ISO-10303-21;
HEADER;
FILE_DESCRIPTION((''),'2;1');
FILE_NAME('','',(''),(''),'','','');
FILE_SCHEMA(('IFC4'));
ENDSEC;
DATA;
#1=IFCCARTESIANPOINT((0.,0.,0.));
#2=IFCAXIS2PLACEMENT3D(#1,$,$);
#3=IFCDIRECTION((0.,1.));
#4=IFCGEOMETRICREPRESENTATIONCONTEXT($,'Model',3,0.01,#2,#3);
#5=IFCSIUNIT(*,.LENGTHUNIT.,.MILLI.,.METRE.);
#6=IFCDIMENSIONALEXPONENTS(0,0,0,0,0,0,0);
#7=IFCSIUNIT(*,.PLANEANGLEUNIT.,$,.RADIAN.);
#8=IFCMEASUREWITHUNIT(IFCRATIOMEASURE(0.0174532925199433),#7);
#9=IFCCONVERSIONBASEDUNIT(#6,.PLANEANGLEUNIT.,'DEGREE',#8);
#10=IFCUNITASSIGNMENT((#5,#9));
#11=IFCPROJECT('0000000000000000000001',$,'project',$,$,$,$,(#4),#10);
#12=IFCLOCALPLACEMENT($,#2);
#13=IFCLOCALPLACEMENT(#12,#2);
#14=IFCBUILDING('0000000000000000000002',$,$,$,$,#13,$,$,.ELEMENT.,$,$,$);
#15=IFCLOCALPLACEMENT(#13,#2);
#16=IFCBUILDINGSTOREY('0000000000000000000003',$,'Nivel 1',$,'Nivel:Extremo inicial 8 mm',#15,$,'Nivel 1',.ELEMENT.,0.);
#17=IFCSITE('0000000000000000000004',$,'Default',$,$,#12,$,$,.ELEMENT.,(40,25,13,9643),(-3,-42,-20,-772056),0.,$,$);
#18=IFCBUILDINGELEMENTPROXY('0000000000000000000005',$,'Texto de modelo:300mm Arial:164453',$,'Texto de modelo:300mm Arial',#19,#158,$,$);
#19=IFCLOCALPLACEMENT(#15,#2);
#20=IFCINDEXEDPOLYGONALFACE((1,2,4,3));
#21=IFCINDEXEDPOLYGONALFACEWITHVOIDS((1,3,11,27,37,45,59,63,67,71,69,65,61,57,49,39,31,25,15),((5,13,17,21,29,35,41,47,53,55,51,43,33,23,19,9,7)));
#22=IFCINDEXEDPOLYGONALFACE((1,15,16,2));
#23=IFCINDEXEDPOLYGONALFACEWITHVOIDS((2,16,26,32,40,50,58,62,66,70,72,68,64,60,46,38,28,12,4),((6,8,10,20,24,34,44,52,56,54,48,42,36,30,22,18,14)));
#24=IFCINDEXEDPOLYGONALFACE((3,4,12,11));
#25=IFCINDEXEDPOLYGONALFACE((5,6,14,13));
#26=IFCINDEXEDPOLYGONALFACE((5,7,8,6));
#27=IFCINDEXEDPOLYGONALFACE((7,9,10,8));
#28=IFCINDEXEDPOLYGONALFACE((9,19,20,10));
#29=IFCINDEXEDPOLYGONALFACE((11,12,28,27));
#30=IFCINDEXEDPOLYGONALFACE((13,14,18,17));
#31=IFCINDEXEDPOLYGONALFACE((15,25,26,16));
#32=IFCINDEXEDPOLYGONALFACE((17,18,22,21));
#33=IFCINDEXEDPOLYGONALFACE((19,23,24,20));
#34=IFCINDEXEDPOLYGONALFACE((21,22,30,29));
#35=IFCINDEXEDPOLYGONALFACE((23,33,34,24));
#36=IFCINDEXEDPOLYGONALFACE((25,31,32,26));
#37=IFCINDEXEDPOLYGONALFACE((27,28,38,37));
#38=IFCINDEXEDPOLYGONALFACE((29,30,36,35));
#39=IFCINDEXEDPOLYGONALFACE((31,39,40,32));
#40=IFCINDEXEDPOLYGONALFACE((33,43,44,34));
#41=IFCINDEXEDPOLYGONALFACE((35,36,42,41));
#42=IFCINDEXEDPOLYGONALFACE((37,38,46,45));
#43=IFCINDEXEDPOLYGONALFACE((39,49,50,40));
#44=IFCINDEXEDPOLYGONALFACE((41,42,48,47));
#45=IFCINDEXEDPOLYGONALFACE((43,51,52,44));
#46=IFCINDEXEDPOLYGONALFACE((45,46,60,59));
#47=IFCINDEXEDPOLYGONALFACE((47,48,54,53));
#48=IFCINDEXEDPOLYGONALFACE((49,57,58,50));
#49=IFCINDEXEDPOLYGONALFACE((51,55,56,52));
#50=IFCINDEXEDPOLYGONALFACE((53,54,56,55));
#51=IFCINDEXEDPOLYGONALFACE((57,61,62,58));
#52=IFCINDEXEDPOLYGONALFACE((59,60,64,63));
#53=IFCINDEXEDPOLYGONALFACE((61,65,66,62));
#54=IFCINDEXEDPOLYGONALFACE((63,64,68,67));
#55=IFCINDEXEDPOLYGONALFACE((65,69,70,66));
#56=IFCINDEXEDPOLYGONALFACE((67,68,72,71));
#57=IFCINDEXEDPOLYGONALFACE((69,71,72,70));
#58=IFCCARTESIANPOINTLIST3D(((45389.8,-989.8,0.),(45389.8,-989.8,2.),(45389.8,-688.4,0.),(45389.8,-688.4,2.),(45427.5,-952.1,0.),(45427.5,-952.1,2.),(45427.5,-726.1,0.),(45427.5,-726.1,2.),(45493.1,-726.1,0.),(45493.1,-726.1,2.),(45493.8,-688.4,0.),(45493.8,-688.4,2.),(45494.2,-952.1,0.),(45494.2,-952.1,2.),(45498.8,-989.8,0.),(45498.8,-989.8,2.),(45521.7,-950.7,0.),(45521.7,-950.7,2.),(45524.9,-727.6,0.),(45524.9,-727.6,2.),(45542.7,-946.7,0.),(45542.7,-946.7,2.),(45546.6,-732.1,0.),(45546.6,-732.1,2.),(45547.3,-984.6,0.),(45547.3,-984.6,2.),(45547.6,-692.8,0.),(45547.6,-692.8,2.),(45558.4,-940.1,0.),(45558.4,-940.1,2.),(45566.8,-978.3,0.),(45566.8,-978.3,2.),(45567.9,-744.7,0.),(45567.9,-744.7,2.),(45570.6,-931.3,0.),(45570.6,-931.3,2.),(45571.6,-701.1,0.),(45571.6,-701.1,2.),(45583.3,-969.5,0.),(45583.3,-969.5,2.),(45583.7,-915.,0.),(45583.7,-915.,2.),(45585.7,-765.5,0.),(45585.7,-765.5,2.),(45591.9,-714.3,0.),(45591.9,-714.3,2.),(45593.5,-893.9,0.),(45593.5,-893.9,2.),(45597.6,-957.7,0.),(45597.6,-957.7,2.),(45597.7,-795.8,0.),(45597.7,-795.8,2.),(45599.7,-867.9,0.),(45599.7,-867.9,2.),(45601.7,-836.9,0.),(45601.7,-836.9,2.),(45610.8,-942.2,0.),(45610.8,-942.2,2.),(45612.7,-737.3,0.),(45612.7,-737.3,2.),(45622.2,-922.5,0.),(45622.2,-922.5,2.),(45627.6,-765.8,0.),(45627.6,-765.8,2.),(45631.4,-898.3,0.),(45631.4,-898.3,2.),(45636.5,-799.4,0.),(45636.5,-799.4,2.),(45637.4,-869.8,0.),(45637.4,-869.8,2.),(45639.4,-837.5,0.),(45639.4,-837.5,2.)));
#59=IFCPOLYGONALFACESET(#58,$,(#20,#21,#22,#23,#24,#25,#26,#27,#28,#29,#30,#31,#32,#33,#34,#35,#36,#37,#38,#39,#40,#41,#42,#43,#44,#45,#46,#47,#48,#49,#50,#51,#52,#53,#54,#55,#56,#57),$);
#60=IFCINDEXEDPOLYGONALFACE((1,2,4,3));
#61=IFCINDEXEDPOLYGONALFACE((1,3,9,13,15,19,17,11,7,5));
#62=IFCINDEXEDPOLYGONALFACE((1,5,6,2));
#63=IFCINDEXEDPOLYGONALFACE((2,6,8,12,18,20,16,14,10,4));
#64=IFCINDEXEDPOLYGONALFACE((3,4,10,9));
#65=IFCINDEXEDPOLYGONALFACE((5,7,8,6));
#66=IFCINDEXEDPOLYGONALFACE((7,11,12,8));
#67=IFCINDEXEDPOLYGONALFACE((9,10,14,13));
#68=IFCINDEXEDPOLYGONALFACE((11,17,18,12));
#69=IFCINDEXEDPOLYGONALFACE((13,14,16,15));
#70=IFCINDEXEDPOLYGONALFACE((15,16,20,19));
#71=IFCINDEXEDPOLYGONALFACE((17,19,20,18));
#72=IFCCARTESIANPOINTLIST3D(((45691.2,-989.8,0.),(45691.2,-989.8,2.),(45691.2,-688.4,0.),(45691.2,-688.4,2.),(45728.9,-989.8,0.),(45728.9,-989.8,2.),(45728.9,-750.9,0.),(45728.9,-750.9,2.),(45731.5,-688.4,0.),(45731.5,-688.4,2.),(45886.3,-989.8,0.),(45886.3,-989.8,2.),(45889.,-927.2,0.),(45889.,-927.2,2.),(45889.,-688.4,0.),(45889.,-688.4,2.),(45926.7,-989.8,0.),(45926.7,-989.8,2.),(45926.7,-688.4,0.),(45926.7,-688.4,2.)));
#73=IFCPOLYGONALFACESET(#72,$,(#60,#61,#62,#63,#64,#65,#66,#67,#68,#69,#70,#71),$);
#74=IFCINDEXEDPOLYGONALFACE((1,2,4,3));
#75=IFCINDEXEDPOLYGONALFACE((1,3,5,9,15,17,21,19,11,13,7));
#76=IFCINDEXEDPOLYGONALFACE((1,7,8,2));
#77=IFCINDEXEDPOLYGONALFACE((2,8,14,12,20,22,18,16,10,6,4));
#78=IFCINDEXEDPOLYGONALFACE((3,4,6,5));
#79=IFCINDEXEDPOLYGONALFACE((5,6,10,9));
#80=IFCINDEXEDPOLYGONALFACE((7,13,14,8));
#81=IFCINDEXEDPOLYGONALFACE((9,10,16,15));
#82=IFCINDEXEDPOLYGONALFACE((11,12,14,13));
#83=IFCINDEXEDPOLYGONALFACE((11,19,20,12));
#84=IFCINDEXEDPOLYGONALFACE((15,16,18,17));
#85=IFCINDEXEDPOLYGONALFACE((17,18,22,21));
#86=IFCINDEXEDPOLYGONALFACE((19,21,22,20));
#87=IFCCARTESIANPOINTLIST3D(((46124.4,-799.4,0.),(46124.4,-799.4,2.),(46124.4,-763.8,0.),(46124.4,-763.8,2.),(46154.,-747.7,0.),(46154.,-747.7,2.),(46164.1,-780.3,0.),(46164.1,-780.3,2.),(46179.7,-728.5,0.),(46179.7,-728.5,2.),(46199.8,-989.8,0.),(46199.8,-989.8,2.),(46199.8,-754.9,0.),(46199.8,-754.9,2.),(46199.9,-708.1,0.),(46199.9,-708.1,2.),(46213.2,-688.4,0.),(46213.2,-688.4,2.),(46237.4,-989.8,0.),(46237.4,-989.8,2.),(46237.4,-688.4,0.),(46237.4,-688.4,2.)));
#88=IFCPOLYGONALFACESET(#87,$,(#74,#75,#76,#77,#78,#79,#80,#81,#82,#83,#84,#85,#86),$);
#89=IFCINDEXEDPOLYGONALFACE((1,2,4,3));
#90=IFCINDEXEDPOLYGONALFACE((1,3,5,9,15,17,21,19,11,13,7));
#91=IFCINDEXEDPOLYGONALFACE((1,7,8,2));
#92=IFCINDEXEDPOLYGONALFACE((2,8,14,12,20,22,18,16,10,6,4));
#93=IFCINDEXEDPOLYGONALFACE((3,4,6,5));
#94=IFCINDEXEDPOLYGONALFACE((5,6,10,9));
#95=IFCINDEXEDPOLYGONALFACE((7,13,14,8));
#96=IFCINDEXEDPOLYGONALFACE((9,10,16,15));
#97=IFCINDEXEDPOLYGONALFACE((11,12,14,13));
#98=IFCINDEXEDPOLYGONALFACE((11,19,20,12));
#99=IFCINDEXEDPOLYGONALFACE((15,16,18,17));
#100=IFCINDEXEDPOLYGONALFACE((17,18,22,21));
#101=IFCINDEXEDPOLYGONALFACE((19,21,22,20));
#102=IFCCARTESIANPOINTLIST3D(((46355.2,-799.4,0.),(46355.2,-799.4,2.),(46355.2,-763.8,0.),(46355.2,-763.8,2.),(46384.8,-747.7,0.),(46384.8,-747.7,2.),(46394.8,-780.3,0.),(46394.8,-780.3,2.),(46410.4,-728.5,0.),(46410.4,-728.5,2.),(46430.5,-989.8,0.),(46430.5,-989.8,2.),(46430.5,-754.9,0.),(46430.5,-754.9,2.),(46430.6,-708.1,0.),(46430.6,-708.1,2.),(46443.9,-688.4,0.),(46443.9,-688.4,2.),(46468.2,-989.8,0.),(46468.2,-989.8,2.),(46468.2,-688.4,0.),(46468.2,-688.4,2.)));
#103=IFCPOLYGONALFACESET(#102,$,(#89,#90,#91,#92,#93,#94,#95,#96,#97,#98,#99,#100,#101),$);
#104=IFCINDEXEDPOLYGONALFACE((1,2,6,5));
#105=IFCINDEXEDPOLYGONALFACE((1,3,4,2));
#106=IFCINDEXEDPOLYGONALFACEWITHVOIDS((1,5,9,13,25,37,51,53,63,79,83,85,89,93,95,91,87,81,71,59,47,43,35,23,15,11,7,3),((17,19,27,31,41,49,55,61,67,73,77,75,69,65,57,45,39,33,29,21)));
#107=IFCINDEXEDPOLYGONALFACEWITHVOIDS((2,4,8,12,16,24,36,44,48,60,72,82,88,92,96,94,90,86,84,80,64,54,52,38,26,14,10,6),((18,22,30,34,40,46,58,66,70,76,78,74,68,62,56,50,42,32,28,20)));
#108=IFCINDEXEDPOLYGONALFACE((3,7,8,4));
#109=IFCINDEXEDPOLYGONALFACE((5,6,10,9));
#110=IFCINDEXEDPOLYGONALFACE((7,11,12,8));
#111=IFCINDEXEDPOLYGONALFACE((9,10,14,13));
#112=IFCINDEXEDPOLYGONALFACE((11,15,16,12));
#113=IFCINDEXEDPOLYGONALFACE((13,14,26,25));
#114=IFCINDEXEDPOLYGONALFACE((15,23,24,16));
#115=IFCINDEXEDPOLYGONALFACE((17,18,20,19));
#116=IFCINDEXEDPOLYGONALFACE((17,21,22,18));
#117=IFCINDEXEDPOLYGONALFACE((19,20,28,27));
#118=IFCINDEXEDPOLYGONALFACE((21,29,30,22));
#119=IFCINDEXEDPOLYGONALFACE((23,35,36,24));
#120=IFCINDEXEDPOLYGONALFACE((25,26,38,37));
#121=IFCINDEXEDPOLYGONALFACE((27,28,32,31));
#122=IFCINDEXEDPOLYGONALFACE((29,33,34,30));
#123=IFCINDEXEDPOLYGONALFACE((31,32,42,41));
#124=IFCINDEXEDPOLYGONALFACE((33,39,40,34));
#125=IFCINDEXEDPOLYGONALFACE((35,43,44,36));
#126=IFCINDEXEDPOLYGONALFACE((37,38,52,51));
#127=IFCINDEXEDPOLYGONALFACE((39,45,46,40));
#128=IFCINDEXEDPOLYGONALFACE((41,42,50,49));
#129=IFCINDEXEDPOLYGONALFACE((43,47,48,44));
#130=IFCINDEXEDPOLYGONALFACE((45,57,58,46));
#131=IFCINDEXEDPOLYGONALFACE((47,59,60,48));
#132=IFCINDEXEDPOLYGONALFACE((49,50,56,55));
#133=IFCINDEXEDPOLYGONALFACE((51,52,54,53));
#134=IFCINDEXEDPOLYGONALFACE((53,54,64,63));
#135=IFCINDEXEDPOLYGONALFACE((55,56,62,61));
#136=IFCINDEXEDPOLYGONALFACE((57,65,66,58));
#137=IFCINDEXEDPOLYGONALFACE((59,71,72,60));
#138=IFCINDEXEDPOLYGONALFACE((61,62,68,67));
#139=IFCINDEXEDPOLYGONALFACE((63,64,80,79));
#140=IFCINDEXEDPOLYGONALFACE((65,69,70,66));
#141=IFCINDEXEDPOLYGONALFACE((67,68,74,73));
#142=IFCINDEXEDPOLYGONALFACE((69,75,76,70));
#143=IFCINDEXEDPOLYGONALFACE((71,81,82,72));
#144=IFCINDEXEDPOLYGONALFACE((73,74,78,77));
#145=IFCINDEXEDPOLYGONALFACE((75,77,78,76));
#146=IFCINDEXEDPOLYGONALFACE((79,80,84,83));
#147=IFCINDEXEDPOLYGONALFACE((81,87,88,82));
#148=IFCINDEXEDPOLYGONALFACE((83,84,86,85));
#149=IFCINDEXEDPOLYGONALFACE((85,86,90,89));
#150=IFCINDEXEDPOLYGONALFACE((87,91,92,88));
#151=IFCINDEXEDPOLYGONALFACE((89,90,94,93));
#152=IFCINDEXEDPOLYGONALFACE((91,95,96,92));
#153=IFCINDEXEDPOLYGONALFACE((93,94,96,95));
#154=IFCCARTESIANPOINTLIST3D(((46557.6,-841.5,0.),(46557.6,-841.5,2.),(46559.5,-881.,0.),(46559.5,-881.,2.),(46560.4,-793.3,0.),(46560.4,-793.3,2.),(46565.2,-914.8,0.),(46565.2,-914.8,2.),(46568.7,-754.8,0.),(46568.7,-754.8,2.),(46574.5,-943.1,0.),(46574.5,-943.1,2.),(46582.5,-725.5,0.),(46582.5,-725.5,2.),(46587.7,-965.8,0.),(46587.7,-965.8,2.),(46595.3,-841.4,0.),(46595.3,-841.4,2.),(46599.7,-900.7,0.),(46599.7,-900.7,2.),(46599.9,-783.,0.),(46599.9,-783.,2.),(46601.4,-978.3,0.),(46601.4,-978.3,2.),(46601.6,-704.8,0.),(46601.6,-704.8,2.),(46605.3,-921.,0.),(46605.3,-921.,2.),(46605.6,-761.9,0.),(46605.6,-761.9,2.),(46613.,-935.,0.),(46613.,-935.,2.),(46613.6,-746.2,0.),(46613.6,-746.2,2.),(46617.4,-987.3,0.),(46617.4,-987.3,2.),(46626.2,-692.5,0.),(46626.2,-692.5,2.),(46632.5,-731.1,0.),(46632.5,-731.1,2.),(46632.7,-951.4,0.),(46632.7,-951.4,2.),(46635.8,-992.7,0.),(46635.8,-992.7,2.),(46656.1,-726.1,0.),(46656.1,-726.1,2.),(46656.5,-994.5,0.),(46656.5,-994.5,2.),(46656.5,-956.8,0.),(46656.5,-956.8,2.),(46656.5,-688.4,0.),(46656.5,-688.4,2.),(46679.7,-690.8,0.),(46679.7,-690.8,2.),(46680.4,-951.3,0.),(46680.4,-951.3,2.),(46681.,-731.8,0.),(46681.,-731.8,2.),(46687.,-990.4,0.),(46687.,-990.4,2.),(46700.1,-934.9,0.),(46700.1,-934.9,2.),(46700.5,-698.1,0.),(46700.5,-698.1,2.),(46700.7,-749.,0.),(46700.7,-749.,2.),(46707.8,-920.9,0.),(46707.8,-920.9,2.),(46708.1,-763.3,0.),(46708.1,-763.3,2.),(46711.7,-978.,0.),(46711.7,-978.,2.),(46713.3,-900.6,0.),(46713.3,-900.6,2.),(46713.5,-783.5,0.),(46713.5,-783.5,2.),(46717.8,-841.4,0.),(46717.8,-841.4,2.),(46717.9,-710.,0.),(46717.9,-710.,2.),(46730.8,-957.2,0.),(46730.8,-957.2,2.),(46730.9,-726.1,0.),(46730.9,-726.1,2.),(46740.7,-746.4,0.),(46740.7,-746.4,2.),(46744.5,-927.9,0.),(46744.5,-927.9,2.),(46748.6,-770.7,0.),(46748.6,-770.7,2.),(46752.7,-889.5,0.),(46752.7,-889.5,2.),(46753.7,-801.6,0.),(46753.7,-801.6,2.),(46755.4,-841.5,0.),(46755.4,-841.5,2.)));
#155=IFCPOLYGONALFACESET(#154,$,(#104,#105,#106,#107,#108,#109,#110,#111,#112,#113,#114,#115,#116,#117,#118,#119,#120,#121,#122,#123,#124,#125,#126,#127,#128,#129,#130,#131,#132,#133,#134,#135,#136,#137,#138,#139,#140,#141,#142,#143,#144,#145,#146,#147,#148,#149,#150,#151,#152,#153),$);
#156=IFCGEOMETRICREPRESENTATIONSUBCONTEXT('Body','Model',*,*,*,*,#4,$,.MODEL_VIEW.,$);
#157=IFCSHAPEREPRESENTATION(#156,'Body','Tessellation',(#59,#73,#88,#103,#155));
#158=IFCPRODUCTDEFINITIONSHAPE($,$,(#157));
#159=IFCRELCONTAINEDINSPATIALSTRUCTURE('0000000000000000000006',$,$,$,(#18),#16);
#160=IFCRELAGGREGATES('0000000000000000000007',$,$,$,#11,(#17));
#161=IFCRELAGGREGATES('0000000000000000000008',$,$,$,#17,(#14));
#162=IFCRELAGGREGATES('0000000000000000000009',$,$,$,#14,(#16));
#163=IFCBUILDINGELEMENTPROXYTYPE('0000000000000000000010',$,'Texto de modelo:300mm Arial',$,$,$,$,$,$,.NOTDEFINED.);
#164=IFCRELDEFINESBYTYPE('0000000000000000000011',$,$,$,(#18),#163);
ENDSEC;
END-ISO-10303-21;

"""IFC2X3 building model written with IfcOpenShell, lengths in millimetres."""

from ifc_helpers import new_model, entity, si_unit, converted_unit, direction, frame, origin, place, context, subcontext, project, spatial, polyline, outline, extrude, type_object, element, save


model = new_model("IFC2X3")

# Units and contexts
model_context = context("Model", 3, precision=0.01, world=origin(), true_north=direction((0.0, 1.0)))
body_context = subcontext(model_context, "Body", "Model", "MODEL_VIEW")
ifc_project = project(units=[si_unit("LENGTHUNIT", "METRE", prefix="MILLI"), converted_unit("PLANEANGLEUNIT", "DEGREE", entity("IfcRatioMeasure", 0.0174532925199433), si_unit("PLANEANGLEUNIT", "RADIAN"), dimensions=[0, 0, 0, 0, 0, 0, 0])], contexts=[model_context])

# Site, building, storey
site_placement = place(None, origin())
site = spatial("IfcSite", under=ifc_project, at=site_placement, Name="Default", CompositionType="ELEMENT", RefLatitude=(40, 25, 13, 9643), RefLongitude=(-3, -42, -20, -772056), RefElevation=0.0)
building_placement = place(site_placement, origin())
building = spatial("IfcBuilding", under=site, at=building_placement, CompositionType="ELEMENT")
storey_placement = place(building_placement, origin())
storey = spatial("IfcBuildingStorey", under=building, at=storey_placement, Name="Nivel 1", ObjectType="Nivel:Extremo inicial 8 mm", LongName="Nivel 1", CompositionType="ELEMENT", Elevation=0.0)

# Building element proxy
building_element_proxy_type_1 = type_object("IfcBuildingElementProxyType", Name="Texto de modelo:300mm Arial", PredefinedType="NOTDEFINED")
proxy_1_placement = place(storey_placement, frame((45389.8, -994.5, 0.0)))
element("IfcBuildingElementProxy", 1, at=proxy_1_placement, inside=storey, type_object=building_element_proxy_type_1, Name="Texto de modelo:300mm Arial:164453", ObjectType="Texto de modelo:300mm Arial", context=body_context, shape_type="SweptSolid", body=[
    extrude(outline(polyline([(-178.4, -141.0), (-69.4, -141.0), (-21.0, -135.8), (-1.4, -129.5), (15.0, -120.7), (29.4, -108.9), (42.6, -93.4), (54.0, -73.7), (63.2, -49.5), (69.2, -21.0), (71.2, 11.3), (68.2, 49.4), (59.3, 83.0), (44.5, 111.5), (23.7, 134.5), (3.4, 147.7), (-20.6, 156.1), (-74.4, 160.4), (-178.4, 160.4), (-178.4, -141.0)]), holes=[polyline([(-140.7, -103.3), (-140.7, 122.7), (-75.1, 122.7), (-43.3, 121.2), (-21.7, 116.7), (-0.4, 104.1), (17.4, 83.3), (29.5, 53.0), (33.5, 11.9), (31.5, -19.1), (25.3, -45.1), (15.5, -66.2), (2.4, -82.5), (-9.8, -91.3), (-25.6, -97.9), (-46.5, -101.9), (-74.1, -103.3), (-140.7, -103.3)])]), frame((178.4, 145.7, 0.0)), (0.0, 0.0, 1.0), 2.0),
    extrude(outline(polyline([(-117.7, -150.7), (-80.1, -150.7), (-80.1, 88.1), (77.4, -150.7), (117.7, -150.7), (117.7, 150.7), (80.1, 150.7), (80.1, -88.1), (-77.4, 150.7), (-117.7, 150.7), (-117.7, -150.7)])), frame((419.1, 155.4, 0.0)), (0.0, 0.0, 1.0), 2.0),
    extrude(outline(polyline([(-204.4, -52.5), (97.0, -52.5), (97.0, -28.2), (77.2, -14.9), (56.9, 5.3), (37.7, 30.9), (21.6, 60.5), (-14.0, 60.5), (5.0, 20.8), (30.4, -14.9), (-204.4, -14.9), (-204.4, -52.5)])), frame((795.1, 209.1, 0.0), z_axis=(0.0, 0.0, 1.0), x_axis=(0.0, 1.0, 0.0)), (0.0, 0.0, 1.0), 2.0),
    extrude(outline(polyline([(-204.4, -52.5), (97.0, -52.5), (97.0, -28.2), (77.2, -14.9), (56.9, 5.3), (37.7, 30.9), (21.6, 60.5), (-14.0, 60.5), (5.0, 20.8), (30.4, -14.9), (-204.4, -14.9), (-204.4, -52.5)])), frame((1025.8, 209.1, 0.0), z_axis=(0.0, 0.0, 1.0), x_axis=(0.0, 1.0, 0.0)), (0.0, 0.0, 1.0), 2.0),
    extrude(outline(polyline([(-5.6, -99.5), (33.9, -99.5), (68.0, -95.5), (96.7, -87.5), (120.0, -75.5), (133.2, -62.4), (142.9, -46.8), (149.1, -28.7), (151.9, -8.0), (149.2, 22.6), (138.0, 47.8), (118.2, 67.9), (89.5, 82.9), (51.6, 93.0), (3.8, 98.0), (-36.2, 98.2), (-67.3, 94.5), (-91.9, 87.9), (-112.6, 79.0), (-129.4, 66.8), (-142.0, 50.0), (-150.3, 29.6), (-153.8, 6.5), (-151.2, -23.9), (-140.1, -49.1), (-120.3, -69.2), (-91.7, -84.4), (-53.6, -94.5), (-5.6, -99.5)]), holes=[polyline([(-3.9, -61.9), (-62.1, -54.6), (-82.9, -47.9), (-98.1, -39.2), (-112.3, -19.5), (-116.2, 4.3), (-109.3, 28.9), (-91.2, 47.7), (-76.5, 54.5), (-56.1, 58.9), (1.9, 60.4), (60.8, 53.2), (80.8, 46.7), (94.5, 38.3), (109.9, 17.8), (114.3, -6.3), (107.7, -29.8), (90.4, -48.7), (76.0, -55.8), (55.5, -60.3), (-3.9, -61.9)])]), frame((1267.5, 152.1, 0.0), z_axis=(0.0, 0.0, 1.0), x_axis=(0.047515, -0.998871, 0.0)), (0.0, 0.0, 1.0), 2.0),
])

save(model, "model.ifc")
